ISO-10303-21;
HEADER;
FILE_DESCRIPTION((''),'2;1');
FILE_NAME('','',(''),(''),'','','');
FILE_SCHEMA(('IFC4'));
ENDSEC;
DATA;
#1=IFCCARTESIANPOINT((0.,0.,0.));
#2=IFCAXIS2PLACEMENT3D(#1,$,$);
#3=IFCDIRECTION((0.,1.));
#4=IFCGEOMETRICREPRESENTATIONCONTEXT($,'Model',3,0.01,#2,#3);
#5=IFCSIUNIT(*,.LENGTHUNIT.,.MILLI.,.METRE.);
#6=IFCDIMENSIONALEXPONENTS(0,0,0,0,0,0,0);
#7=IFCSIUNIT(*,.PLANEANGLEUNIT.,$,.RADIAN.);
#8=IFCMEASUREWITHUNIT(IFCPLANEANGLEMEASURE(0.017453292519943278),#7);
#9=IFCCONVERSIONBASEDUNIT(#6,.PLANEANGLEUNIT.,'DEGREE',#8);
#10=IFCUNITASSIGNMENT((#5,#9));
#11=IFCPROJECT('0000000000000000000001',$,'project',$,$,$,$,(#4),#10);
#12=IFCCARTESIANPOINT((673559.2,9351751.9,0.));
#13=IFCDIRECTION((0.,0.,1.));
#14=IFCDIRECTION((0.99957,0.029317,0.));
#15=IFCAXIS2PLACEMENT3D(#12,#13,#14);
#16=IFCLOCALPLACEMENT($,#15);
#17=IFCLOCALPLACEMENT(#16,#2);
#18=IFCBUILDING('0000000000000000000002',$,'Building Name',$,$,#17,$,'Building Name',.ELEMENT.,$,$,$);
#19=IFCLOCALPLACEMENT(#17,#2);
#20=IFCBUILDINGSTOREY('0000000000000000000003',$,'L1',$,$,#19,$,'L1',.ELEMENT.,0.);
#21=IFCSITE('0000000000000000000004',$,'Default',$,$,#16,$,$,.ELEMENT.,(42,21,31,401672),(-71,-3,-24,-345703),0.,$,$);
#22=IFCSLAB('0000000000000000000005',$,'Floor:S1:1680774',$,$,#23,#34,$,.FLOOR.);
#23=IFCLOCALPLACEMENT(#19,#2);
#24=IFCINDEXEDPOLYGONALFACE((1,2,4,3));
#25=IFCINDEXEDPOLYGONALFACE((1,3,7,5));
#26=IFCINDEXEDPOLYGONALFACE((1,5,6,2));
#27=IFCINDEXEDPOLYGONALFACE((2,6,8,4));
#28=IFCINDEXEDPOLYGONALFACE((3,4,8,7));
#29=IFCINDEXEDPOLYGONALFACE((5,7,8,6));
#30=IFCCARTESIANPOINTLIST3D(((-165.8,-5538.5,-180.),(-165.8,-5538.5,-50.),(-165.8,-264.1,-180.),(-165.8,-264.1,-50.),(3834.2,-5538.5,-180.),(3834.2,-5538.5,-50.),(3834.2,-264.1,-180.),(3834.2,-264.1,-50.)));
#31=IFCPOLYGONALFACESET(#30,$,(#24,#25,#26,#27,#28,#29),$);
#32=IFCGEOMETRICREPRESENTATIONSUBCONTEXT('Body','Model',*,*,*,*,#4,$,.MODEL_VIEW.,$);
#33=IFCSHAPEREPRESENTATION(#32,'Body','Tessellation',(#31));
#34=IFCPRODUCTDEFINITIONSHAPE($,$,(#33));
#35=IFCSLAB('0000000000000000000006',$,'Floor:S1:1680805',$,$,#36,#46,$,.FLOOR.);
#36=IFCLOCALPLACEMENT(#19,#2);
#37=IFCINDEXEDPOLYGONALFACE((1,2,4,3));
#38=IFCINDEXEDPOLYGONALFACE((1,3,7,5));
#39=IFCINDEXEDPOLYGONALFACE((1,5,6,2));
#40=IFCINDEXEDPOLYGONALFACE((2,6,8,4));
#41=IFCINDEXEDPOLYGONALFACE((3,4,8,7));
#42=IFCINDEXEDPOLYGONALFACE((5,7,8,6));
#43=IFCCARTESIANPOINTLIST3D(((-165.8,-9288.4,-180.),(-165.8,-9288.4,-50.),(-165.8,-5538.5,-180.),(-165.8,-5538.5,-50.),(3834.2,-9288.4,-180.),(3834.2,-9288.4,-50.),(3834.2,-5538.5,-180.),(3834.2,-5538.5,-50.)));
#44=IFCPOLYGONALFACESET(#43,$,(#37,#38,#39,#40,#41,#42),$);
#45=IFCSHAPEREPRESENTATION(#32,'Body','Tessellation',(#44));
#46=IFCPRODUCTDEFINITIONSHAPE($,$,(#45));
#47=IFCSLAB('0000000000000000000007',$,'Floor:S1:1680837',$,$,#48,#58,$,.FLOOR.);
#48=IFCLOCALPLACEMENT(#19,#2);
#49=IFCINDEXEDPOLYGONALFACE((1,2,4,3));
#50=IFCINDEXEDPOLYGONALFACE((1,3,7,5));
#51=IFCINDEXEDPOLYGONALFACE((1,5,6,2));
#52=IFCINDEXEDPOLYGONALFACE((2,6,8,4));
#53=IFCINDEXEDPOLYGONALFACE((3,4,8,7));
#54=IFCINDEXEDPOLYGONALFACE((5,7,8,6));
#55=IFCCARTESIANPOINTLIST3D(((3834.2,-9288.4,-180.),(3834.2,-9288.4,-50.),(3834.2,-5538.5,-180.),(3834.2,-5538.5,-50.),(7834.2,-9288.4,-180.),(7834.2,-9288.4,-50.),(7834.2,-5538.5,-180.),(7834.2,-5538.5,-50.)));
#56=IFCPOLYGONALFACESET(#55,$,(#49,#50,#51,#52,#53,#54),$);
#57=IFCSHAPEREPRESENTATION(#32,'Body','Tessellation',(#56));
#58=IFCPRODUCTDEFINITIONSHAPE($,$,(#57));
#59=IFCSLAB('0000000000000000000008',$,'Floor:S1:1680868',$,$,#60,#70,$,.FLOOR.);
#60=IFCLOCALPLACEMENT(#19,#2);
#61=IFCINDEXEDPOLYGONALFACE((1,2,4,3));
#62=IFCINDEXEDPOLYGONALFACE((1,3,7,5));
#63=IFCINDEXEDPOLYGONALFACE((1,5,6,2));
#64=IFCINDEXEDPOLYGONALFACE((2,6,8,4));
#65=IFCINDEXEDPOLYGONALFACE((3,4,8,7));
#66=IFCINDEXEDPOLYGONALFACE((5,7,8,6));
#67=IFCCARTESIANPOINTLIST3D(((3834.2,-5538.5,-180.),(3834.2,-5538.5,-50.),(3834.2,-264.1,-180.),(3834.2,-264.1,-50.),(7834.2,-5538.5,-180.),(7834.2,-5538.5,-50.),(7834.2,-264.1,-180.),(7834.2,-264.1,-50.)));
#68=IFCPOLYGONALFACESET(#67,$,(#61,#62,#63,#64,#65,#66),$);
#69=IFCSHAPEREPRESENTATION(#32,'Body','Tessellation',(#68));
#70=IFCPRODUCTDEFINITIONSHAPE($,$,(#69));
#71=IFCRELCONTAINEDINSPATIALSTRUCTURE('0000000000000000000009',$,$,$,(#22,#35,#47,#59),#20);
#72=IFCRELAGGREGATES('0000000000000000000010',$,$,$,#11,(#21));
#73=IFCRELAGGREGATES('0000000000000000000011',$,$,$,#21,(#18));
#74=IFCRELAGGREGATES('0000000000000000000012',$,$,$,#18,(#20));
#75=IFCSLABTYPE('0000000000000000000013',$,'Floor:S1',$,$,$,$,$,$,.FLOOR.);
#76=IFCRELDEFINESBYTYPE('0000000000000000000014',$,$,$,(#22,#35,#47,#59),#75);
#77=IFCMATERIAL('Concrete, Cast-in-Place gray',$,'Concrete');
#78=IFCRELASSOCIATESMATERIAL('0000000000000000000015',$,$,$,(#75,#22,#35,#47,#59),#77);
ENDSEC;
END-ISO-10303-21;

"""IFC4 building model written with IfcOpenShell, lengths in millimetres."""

from ifc_helpers import new_model, entity, si_unit, converted_unit, direction, frame, origin, place, context, subcontext, project, spatial, indexed_curve, outline, extrude, material, type_object, element, save


model = new_model("IFC4")

# Units and contexts
model_context = context("Model", 3, precision=0.01, world=origin(), true_north=direction((0.0, 1.0)))
body_context = subcontext(model_context, "Body", "Model", "MODEL_VIEW")
ifc_project = project(units=[si_unit("LENGTHUNIT", "METRE", prefix="MILLI"), converted_unit("PLANEANGLEUNIT", "DEGREE", entity("IfcPlaneAngleMeasure", 0.017453292519943278), si_unit("PLANEANGLEUNIT", "RADIAN"), dimensions=[0, 0, 0, 0, 0, 0, 0])], contexts=[model_context])

# Site, building, storey
site_placement = place(None, frame((673559.2, 9351751.9, 0.0), z_axis=(0.0, 0.0, 1.0), x_axis=(0.99957, 0.029317, 0.0)))
site = spatial("IfcSite", under=ifc_project, at=site_placement, Name="Default", CompositionType="ELEMENT", RefLatitude=(42, 21, 31, 401672), RefLongitude=(-71, -3, -24, -345703), RefElevation=0.0)
building_placement = place(site_placement, origin())
building = spatial("IfcBuilding", under=site, at=building_placement, Name="Building Name", LongName="Building Name", CompositionType="ELEMENT")
storey_placement = place(building_placement, origin())
storey = spatial("IfcBuildingStorey", under=building, at=storey_placement, Name="L1", LongName="L1", CompositionType="ELEMENT", Elevation=0.0)

# Shared definitions
ifc_material = material(Name="Concrete, Cast-in-Place gray", Category="Concrete")

# Slabs
slab_type = type_object("IfcSlabType", Name="Floor:S1", PredefinedType="FLOOR", material=ifc_material)
slab_1_placement = place(storey_placement, origin())
element("IfcSlab", 1, at=slab_1_placement, inside=storey, type_object=slab_type, material=ifc_material, Name="Floor:S1:1680774", PredefinedType="FLOOR", context=body_context, shape_type="SweptSolid", body=[
    extrude(outline(indexed_curve([(-2637.2, -2000.0), (2637.2, -2000.0), (2637.2, 2000.0), (-2637.2, 2000.0), (-2637.2, -2000.0)], self_intersect=False)), frame((1834.2, -2901.3, -50.0), z_axis=(0.0, 0.0, -1.0), x_axis=(0.0, 1.0, 0.0)), (0.0, 0.0, 1.0), 130.0),
])
slab_2_placement = place(storey_placement, origin())
element("IfcSlab", 2, at=slab_2_placement, inside=storey, type_object=slab_type, material=ifc_material, Name="Floor:S1:1680805", PredefinedType="FLOOR", context=body_context, shape_type="SweptSolid", body=[
    extrude(outline(indexed_curve([(-1874.9, -2000.0), (1874.9, -2000.0), (1874.9, 2000.0), (-1874.9, 2000.0), (-1874.9, -2000.0)], self_intersect=False)), frame((1834.2, -7413.5, -50.0), z_axis=(0.0, 0.0, -1.0), x_axis=(0.0, 1.0, 0.0)), (0.0, 0.0, 1.0), 130.0),
])
slab_3_placement = place(storey_placement, origin())
element("IfcSlab", 3, at=slab_3_placement, inside=storey, type_object=slab_type, material=ifc_material, Name="Floor:S1:1680837", PredefinedType="FLOOR", context=body_context, shape_type="SweptSolid", body=[
    extrude(outline(indexed_curve([(-1874.9, -2000.0), (1874.9, -2000.0), (1874.9, 2000.0), (-1874.9, 2000.0), (-1874.9, -2000.0)], self_intersect=False)), frame((5834.2, -7413.5, -50.0), z_axis=(0.0, 0.0, -1.0), x_axis=(0.0, 1.0, 0.0)), (0.0, 0.0, 1.0), 130.0),
])
slab_4_placement = place(storey_placement, origin())
element("IfcSlab", 4, at=slab_4_placement, inside=storey, type_object=slab_type, material=ifc_material, Name="Floor:S1:1680868", PredefinedType="FLOOR", context=body_context, shape_type="SweptSolid", body=[
    extrude(outline(indexed_curve([(-2637.2, -2000.0), (2637.2, -2000.0), (2637.2, 2000.0), (-2637.2, 2000.0), (-2637.2, -2000.0)], self_intersect=False)), frame((5834.2, -2901.3, -50.0), z_axis=(0.0, 0.0, -1.0), x_axis=(0.0, 1.0, 0.0)), (0.0, 0.0, 1.0), 130.0),
])

save(model, "model.ifc")
